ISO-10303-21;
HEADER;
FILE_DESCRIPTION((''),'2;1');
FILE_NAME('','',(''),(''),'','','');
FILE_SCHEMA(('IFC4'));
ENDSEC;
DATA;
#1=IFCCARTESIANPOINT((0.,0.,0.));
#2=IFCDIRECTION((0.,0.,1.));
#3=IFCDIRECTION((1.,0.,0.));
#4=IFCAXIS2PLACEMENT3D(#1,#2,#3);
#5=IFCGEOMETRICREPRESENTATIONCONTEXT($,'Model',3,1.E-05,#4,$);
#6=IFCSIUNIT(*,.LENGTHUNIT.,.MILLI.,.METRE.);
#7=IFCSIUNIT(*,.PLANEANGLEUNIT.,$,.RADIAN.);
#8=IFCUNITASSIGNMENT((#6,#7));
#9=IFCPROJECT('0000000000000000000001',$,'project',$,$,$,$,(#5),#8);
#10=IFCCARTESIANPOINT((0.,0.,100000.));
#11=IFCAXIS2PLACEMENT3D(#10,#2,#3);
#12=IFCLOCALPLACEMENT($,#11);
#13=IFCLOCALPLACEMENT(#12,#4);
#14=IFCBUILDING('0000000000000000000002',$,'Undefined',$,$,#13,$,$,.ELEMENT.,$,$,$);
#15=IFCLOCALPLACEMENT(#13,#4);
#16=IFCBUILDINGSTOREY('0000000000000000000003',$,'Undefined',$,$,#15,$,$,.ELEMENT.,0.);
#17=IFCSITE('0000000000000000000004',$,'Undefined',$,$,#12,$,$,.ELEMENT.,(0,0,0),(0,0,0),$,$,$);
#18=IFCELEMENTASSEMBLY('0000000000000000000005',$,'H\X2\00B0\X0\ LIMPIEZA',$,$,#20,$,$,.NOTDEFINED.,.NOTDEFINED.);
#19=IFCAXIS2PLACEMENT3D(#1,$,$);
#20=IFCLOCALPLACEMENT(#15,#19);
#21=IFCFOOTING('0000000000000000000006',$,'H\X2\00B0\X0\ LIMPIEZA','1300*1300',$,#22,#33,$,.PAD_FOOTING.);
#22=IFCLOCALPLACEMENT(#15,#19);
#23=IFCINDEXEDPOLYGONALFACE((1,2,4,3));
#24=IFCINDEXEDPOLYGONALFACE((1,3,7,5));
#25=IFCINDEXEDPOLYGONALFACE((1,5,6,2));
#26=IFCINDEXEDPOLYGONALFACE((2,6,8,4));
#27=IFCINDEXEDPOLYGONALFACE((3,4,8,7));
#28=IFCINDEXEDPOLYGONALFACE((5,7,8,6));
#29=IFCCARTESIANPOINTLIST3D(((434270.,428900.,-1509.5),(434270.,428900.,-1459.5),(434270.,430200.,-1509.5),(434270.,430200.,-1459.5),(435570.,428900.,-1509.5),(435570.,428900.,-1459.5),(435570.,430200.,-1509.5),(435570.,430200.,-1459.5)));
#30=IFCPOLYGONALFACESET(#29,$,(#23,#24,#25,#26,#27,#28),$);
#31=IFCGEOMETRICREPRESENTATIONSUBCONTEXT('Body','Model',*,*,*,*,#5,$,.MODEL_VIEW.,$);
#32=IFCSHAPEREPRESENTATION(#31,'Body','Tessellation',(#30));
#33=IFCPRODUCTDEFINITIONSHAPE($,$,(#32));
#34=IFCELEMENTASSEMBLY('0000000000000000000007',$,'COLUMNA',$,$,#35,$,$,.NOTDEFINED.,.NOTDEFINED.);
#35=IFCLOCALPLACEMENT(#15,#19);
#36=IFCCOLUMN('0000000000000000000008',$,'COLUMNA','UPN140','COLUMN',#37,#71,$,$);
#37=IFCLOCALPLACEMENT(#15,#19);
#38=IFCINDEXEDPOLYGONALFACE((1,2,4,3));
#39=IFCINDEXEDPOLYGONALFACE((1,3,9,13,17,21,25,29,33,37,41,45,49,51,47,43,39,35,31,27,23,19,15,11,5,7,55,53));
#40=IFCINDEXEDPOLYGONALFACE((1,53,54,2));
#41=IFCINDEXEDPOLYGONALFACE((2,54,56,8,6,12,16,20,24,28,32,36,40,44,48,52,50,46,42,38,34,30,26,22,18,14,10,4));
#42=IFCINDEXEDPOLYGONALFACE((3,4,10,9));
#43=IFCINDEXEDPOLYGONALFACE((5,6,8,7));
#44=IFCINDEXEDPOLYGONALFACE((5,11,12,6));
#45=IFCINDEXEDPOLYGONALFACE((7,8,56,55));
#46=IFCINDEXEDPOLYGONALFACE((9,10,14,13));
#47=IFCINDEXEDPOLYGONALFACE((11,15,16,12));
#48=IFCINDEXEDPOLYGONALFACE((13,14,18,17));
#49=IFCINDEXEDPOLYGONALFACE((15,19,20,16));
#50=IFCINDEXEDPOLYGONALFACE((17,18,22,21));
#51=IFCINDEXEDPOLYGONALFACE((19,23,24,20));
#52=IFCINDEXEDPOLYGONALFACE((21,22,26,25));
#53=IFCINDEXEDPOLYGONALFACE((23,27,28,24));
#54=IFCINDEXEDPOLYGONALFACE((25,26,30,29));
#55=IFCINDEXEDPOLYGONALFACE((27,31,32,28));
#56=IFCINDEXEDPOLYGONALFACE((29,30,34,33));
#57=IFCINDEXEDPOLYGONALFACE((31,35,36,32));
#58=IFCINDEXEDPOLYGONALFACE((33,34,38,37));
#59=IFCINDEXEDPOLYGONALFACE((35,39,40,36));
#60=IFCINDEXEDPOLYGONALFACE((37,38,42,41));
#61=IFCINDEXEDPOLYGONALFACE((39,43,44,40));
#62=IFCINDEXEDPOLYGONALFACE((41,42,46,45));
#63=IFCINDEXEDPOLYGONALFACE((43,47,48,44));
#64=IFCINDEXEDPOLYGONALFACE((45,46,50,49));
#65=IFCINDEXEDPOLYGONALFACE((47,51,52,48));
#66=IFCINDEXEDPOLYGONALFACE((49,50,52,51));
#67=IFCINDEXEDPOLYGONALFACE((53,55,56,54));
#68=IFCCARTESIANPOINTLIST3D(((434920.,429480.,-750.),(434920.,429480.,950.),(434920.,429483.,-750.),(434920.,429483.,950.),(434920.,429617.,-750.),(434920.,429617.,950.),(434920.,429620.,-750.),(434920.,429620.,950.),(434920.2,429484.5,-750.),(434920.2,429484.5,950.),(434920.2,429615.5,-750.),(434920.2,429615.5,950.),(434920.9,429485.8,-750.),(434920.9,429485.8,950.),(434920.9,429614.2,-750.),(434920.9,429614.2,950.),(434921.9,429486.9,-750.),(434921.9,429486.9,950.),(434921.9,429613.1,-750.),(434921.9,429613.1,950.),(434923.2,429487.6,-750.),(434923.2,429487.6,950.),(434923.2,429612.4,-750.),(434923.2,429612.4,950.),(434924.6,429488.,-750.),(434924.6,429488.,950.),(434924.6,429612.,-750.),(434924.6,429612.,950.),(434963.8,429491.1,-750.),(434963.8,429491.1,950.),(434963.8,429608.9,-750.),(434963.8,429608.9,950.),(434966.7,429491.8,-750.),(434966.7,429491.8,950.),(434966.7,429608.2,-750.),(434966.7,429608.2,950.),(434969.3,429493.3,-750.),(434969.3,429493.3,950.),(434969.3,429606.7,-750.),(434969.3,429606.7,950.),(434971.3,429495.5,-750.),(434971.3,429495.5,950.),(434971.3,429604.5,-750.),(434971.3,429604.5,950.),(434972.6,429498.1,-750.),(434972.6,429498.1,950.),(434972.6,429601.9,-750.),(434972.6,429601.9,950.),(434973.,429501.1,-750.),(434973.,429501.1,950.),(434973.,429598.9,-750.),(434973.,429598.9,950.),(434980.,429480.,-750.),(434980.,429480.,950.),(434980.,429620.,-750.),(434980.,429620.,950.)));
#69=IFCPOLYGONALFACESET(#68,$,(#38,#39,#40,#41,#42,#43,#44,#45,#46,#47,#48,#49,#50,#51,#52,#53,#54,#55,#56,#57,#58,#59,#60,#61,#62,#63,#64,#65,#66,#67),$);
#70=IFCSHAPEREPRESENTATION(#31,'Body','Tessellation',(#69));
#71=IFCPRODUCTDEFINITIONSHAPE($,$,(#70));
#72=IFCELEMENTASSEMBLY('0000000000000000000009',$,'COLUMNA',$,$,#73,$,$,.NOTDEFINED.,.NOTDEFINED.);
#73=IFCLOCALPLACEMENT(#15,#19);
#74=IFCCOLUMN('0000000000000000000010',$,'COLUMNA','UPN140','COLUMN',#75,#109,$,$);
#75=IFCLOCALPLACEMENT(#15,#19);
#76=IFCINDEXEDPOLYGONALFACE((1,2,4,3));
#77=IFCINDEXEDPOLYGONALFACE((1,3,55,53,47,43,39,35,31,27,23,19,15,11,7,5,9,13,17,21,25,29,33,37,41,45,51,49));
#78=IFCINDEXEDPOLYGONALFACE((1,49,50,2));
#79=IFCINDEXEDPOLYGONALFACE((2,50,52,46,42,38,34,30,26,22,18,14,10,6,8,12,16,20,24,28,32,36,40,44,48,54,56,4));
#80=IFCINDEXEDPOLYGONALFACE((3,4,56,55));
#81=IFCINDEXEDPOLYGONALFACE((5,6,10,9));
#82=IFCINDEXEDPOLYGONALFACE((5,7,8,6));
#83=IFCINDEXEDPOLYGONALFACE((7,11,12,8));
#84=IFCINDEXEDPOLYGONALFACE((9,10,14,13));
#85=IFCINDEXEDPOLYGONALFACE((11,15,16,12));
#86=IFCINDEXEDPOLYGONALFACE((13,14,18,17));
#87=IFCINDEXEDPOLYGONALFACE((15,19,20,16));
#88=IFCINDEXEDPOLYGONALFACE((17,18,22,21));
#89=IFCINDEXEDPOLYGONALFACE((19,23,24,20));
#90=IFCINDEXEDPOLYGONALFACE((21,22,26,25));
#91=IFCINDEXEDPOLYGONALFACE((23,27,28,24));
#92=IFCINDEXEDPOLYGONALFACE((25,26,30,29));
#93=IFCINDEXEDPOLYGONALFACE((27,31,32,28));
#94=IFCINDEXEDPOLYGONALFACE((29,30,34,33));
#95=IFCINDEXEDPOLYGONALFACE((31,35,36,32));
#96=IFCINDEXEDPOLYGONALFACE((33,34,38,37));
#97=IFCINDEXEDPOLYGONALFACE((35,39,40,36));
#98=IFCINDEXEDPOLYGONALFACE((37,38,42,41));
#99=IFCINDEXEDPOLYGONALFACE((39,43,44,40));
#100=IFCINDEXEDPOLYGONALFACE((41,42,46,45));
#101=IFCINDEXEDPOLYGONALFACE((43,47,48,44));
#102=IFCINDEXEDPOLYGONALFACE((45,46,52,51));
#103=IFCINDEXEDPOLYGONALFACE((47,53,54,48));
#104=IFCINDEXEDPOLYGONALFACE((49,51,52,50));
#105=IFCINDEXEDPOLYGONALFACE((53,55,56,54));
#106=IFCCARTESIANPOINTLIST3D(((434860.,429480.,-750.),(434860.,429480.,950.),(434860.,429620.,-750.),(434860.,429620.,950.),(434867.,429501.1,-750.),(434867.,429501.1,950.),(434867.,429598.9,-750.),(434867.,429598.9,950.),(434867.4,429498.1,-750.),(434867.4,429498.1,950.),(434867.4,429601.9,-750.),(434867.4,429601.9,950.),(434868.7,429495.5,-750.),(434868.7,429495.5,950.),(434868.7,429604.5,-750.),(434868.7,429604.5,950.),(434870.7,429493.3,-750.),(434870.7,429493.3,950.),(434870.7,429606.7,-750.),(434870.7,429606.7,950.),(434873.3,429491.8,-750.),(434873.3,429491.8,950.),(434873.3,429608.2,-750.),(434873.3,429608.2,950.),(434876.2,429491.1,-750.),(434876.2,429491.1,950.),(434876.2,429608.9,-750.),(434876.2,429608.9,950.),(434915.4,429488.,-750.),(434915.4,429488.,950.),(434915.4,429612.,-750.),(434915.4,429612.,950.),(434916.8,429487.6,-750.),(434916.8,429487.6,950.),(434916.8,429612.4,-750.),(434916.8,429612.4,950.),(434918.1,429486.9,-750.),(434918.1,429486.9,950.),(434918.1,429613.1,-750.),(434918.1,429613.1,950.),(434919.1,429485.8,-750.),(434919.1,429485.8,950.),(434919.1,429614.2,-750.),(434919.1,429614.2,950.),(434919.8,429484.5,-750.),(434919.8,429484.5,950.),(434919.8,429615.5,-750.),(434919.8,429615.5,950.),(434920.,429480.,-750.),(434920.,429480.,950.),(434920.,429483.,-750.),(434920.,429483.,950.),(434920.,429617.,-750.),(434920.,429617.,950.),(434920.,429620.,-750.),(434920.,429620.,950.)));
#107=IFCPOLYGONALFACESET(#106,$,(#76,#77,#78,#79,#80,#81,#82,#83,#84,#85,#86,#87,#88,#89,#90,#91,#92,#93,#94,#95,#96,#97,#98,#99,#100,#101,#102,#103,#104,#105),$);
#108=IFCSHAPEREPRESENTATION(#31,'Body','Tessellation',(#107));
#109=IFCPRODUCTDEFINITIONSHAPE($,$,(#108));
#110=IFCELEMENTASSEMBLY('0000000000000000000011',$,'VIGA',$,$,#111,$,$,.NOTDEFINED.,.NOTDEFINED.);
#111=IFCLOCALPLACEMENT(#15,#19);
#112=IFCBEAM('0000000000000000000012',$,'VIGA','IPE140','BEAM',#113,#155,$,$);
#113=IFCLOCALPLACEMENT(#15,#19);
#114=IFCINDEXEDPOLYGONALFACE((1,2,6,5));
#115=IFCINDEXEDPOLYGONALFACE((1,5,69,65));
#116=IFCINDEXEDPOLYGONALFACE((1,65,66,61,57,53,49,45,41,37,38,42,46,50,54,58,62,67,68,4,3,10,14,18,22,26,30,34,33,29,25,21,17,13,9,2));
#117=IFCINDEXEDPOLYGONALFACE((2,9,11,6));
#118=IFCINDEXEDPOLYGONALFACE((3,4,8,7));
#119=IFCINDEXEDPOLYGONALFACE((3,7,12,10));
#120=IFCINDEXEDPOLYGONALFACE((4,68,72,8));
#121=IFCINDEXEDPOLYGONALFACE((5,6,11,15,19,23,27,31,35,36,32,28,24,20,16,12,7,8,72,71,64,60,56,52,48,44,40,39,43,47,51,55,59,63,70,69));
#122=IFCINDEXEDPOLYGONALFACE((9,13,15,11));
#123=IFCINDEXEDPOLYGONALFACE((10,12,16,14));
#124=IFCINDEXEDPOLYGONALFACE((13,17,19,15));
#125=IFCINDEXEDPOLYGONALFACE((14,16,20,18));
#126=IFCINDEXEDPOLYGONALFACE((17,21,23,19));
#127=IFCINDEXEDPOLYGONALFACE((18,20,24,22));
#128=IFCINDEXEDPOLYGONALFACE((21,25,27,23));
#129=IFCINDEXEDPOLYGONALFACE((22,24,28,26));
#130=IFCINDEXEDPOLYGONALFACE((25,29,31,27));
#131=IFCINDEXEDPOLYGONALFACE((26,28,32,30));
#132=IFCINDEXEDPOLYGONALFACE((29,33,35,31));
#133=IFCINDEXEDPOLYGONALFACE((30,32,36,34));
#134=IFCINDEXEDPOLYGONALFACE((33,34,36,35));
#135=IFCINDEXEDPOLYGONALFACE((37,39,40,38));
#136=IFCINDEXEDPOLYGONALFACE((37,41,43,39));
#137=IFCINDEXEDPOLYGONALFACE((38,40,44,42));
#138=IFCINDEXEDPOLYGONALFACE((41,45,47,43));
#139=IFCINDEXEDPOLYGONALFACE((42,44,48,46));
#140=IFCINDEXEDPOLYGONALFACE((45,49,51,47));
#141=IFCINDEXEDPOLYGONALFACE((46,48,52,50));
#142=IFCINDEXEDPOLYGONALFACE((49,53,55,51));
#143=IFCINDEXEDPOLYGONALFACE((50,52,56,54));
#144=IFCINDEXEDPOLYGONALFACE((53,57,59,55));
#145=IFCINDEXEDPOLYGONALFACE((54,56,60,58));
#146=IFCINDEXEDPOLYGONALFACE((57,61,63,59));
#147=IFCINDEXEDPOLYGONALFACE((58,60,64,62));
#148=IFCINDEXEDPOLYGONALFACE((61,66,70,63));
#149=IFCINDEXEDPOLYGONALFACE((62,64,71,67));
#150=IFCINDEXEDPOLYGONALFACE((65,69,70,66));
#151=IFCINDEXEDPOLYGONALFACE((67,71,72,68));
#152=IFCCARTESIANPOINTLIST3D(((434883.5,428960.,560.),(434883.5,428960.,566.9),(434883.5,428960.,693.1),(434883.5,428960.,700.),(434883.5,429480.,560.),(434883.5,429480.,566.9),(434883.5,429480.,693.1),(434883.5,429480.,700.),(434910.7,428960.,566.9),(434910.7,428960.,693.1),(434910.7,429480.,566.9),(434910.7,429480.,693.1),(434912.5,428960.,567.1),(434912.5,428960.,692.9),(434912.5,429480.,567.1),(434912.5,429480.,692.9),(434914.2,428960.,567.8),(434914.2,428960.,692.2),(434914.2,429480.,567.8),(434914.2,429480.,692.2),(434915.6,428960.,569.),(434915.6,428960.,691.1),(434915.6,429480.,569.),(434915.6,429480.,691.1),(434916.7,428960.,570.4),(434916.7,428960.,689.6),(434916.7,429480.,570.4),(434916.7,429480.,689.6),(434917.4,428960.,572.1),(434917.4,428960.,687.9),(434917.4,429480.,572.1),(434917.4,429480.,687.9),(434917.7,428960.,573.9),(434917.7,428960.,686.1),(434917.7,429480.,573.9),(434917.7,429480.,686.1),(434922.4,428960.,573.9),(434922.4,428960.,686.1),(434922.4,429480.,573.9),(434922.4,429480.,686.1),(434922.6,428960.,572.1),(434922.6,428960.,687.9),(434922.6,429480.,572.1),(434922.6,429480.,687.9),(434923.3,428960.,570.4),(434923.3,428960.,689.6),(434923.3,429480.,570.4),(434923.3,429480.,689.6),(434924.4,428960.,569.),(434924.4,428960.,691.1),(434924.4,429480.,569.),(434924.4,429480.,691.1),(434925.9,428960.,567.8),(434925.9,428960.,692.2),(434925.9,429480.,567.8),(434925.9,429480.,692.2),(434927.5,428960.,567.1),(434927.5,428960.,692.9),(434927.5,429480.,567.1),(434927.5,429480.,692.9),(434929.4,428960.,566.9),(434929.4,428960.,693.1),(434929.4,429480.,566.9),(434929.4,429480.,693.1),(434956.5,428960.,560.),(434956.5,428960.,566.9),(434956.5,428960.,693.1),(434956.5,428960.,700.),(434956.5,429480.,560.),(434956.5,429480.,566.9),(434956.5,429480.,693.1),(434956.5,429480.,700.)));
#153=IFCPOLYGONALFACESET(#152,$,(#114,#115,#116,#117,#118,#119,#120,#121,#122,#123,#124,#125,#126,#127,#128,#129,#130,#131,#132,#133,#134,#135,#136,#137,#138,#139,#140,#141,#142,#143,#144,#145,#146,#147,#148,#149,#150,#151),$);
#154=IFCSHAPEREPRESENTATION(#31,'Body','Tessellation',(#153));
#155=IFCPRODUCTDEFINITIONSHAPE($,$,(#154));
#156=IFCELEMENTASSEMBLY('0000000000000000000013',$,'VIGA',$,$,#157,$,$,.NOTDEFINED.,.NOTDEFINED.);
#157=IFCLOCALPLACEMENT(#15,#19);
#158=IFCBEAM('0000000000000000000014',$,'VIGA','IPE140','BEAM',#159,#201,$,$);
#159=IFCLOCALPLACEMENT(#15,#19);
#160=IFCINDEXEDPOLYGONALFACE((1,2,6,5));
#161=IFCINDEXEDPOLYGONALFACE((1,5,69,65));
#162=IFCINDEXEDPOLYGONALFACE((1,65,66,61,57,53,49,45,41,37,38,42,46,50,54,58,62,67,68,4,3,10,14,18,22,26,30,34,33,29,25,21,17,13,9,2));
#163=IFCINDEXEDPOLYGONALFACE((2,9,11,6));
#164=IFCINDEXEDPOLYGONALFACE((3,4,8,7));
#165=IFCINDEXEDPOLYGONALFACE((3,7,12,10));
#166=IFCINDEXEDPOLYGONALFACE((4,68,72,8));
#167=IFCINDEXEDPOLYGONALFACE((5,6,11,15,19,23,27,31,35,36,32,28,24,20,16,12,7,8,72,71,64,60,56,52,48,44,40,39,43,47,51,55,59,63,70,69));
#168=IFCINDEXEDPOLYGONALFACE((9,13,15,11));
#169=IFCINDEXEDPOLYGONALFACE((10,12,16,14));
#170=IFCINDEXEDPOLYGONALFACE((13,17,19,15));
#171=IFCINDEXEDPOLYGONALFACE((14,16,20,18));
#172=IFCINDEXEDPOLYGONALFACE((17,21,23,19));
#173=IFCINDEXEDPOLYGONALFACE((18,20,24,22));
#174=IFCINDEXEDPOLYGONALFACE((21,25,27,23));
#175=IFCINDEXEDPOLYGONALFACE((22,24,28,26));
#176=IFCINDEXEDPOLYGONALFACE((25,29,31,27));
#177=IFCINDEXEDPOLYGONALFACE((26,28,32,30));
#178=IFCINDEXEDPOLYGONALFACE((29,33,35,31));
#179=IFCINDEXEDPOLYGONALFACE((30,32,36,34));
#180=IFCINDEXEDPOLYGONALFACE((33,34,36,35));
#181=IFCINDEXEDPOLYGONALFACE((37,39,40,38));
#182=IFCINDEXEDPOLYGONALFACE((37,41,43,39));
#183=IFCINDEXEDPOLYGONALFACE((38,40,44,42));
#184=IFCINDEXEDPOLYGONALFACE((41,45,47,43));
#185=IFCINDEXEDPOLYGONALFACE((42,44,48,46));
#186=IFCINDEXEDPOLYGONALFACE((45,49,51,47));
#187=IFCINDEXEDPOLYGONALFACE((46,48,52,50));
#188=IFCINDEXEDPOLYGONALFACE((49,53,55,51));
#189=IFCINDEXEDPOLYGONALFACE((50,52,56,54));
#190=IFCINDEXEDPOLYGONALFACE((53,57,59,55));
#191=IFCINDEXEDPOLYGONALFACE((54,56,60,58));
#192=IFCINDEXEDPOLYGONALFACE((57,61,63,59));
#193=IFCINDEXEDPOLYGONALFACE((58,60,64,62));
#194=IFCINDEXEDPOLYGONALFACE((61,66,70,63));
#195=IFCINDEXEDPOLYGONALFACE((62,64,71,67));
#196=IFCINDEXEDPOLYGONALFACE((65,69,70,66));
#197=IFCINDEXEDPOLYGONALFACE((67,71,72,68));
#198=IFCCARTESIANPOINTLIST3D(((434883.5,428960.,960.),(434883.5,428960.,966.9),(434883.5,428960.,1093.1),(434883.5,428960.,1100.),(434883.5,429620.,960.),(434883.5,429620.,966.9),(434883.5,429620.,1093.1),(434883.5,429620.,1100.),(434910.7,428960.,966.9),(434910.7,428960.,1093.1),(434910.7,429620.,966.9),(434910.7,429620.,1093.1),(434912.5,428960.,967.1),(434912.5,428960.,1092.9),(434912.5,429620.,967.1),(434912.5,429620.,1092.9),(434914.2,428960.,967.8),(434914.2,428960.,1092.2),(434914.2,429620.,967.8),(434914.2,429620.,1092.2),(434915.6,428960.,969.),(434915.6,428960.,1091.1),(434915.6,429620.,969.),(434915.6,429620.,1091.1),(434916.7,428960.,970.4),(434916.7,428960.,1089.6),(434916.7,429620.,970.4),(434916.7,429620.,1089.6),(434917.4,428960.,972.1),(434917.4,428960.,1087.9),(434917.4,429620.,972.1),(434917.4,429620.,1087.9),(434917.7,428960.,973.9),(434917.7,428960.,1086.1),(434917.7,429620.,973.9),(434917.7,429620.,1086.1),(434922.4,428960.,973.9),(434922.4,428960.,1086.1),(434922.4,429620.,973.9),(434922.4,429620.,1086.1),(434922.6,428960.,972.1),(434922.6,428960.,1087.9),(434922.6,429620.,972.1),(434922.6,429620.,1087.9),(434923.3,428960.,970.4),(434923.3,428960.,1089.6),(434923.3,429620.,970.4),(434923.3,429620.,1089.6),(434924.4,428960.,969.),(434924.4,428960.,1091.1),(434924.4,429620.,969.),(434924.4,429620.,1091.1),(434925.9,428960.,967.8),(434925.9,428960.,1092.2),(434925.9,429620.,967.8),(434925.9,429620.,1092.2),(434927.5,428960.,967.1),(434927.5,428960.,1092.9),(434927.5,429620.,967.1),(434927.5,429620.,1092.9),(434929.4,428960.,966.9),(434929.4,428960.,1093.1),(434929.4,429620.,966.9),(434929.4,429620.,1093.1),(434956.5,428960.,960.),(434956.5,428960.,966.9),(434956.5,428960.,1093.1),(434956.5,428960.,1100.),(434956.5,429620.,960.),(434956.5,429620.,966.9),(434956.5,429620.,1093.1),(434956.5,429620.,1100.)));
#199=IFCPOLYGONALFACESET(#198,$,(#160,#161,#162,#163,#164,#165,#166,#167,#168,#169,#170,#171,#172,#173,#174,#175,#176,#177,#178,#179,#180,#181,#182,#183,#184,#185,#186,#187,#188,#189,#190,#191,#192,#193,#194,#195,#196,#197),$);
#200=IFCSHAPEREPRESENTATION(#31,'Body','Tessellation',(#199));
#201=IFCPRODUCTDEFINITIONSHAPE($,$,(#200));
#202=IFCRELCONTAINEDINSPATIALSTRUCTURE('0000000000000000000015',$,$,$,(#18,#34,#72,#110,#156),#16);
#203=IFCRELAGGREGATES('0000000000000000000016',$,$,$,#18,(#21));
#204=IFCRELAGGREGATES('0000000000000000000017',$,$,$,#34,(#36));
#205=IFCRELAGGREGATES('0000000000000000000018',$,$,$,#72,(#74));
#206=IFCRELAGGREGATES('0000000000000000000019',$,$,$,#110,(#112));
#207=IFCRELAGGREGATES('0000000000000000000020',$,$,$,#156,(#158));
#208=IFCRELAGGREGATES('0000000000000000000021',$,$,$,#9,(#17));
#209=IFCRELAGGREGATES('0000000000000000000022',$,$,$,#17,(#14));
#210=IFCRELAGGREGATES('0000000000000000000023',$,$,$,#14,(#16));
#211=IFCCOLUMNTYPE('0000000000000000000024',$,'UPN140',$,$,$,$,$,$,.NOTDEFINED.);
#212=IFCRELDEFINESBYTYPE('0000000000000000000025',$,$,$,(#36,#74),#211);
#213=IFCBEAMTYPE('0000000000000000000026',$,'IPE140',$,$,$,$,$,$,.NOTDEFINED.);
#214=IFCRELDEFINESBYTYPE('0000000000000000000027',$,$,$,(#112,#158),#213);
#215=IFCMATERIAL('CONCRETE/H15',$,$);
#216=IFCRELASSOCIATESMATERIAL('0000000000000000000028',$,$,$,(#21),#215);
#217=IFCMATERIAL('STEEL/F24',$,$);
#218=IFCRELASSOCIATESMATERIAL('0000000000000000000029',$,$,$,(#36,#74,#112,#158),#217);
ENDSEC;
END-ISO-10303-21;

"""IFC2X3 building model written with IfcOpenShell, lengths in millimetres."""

from ifc_helpers import new_model, si_unit, frame, origin_with_axes, origin_2d_with_axis, place, context, subcontext, project, spatial, rectangle, i_section, u_section, extrude, material, type_object, element, aggregate, save


model = new_model("IFC2X3")

# Units and contexts
model_context = context("Model", 3, precision=1e-05, world=origin_with_axes())
body_context = subcontext(model_context, "Body", "Model", "MODEL_VIEW")
ifc_project = project(units=[si_unit("LENGTHUNIT", "METRE", prefix="MILLI"), si_unit("PLANEANGLEUNIT", "RADIAN")], contexts=[model_context])

# Site, building, storey
site_placement = place(None, frame((0.0, 0.0, 100000.0), z_axis=(0.0, 0.0, 1.0), x_axis=(1.0, 0.0, 0.0)))
site = spatial("IfcSite", under=ifc_project, at=site_placement, Name="Undefined", CompositionType="ELEMENT", RefLatitude=(0, 0, 0), RefLongitude=(0, 0, 0))
building_placement = place(site_placement, origin_with_axes())
building = spatial("IfcBuilding", under=site, at=building_placement, Name="Undefined", CompositionType="ELEMENT")
storey_placement = place(building_placement, origin_with_axes())
storey = spatial("IfcBuildingStorey", under=building, at=storey_placement, Name="Undefined", CompositionType="ELEMENT", Elevation=0.0)

# Element assembly, footing
assembly_1_placement = place(storey_placement, origin_with_axes())
assembly_1 = element("IfcElementAssembly", 1, at=assembly_1_placement, inside=storey, Name="H° LIMPIEZA", AssemblyPlace="NOTDEFINED", PredefinedType="NOTDEFINED")
ifc_material_1 = material(Name="CONCRETE/H15")
footing_placement = place(assembly_1_placement, frame((434920.0, 429550.0, -1509.5), z_axis=(0.0, 1.0, 0.0), x_axis=(0.0, 0.0, 1.0)))
footing = element("IfcFooting", 2, at=footing_placement, material=ifc_material_1, Name="H° LIMPIEZA", Description="1300*1300", PredefinedType="PAD_FOOTING", context=body_context, shape_type="SweptSolid", body=[
    extrude(rectangle(XDim=1300.0, YDim=1300.0, at=origin_2d_with_axis()), frame((50.0, 0.0, 0.0), z_axis=(-1.0, 0.0, 0.0), x_axis=(0.0, -1.0, 0.0)), (0.0, 0.0, 1.0), 50.0),
])
aggregate(assembly_1, [footing])

# Element assemblies, columns
assembly_2_placement = place(storey_placement, origin_with_axes())
assembly_2 = element("IfcElementAssembly", 3, at=assembly_2_placement, inside=storey, Name="COLUMNA", AssemblyPlace="NOTDEFINED", PredefinedType="NOTDEFINED")
ifc_material_2 = material(Name="STEEL/F24")
column_type = type_object("IfcColumnType", Name="UPN140", PredefinedType="NOTDEFINED")
column_1_placement = place(assembly_2_placement, frame((434950.0, 429550.0, 950.0), z_axis=(0.0, 0.0, -1.0), x_axis=(0.0, -1.0, 0.0)))
column_1 = element("IfcColumn", 4, at=column_1_placement, type_object=column_type, material=ifc_material_2, Name="COLUMNA", Description="UPN140", ObjectType="COLUMN", context=body_context, shape_type="SweptSolid", body=[
    extrude(u_section(Depth=140.0, FlangeWidth=60.0, WebThickness=7.0, FlangeThickness=10.0, FilletRadius=10.0, EdgeRadius=5.0, FlangeSlope=0.07983, at=origin_2d_with_axis()), frame((0.0, 0.0, 1700.0), z_axis=(0.0, 0.0, -1.0), x_axis=(0.0, 1.0, 0.0)), (0.0, 0.0, 1.0), 1700.0),
])
aggregate(assembly_2, [column_1])
assembly_3_placement = place(storey_placement, origin_with_axes())
assembly_3 = element("IfcElementAssembly", 5, at=assembly_3_placement, inside=storey, Name="COLUMNA", AssemblyPlace="NOTDEFINED", PredefinedType="NOTDEFINED")
column_2_placement = place(assembly_3_placement, frame((434890.0, 429550.0, -750.0), z_axis=(0.0, 0.0, 1.0), x_axis=(0.0, -1.0, 0.0)))
column_2 = element("IfcColumn", 6, at=column_2_placement, type_object=column_type, material=ifc_material_2, Name="COLUMNA", Description="UPN140", ObjectType="COLUMN", context=body_context, shape_type="SweptSolid", body=[
    extrude(u_section(Depth=140.0, FlangeWidth=60.0, WebThickness=7.0, FlangeThickness=10.0, FilletRadius=10.0, EdgeRadius=5.0, FlangeSlope=0.07983, at=origin_2d_with_axis()), frame((0.0, 0.0, 1700.0), z_axis=(0.0, 0.0, -1.0), x_axis=(0.0, 1.0, 0.0)), (0.0, 0.0, 1.0), 1700.0),
])
aggregate(assembly_3, [column_2])

# Element assemblies, beams
assembly_4_placement = place(storey_placement, origin_with_axes())
assembly_4 = element("IfcElementAssembly", 7, at=assembly_4_placement, inside=storey, Name="VIGA", AssemblyPlace="NOTDEFINED", PredefinedType="NOTDEFINED")
beam_type = type_object("IfcBeamType", Name="IPE140", PredefinedType="NOTDEFINED")
beam_1_placement = place(assembly_4_placement, frame((434920.0, 428960.0, 630.0), z_axis=(0.0, 0.0, 1.0), x_axis=(0.0, 1.0, 0.0)))
beam_1 = element("IfcBeam", 8, at=beam_1_placement, type_object=beam_type, material=ifc_material_2, Name="VIGA", Description="IPE140", ObjectType="BEAM", context=body_context, shape_type="SweptSolid", body=[
    extrude(i_section(OverallWidth=73.0, OverallDepth=140.0, WebThickness=4.7, FlangeThickness=6.9, FilletRadius=7.0, at=origin_2d_with_axis()), frame((520.0, 0.0, 0.0), z_axis=(-1.0, 0.0, 0.0), x_axis=(0.0, -1.0, 0.0)), (0.0, 0.0, 1.0), 520.0),
])
aggregate(assembly_4, [beam_1])
assembly_5_placement = place(storey_placement, origin_with_axes())
assembly_5 = element("IfcElementAssembly", 9, at=assembly_5_placement, inside=storey, Name="VIGA", AssemblyPlace="NOTDEFINED", PredefinedType="NOTDEFINED")
beam_2_placement = place(assembly_5_placement, frame((434920.0, 428960.0, 1030.0), z_axis=(0.0, 0.0, 1.0), x_axis=(0.0, 1.0, 0.0)))
beam_2 = element("IfcBeam", 10, at=beam_2_placement, type_object=beam_type, material=ifc_material_2, Name="VIGA", Description="IPE140", ObjectType="BEAM", context=body_context, shape_type="SweptSolid", body=[
    extrude(i_section(OverallWidth=73.0, OverallDepth=140.0, WebThickness=4.7, FlangeThickness=6.9, FilletRadius=7.0, at=origin_2d_with_axis()), frame((660.0, 0.0, 0.0), z_axis=(-1.0, 0.0, 0.0), x_axis=(0.0, -1.0, 0.0)), (0.0, 0.0, 1.0), 660.0),
])
aggregate(assembly_5, [beam_2])

save(model, "model.ifc")
